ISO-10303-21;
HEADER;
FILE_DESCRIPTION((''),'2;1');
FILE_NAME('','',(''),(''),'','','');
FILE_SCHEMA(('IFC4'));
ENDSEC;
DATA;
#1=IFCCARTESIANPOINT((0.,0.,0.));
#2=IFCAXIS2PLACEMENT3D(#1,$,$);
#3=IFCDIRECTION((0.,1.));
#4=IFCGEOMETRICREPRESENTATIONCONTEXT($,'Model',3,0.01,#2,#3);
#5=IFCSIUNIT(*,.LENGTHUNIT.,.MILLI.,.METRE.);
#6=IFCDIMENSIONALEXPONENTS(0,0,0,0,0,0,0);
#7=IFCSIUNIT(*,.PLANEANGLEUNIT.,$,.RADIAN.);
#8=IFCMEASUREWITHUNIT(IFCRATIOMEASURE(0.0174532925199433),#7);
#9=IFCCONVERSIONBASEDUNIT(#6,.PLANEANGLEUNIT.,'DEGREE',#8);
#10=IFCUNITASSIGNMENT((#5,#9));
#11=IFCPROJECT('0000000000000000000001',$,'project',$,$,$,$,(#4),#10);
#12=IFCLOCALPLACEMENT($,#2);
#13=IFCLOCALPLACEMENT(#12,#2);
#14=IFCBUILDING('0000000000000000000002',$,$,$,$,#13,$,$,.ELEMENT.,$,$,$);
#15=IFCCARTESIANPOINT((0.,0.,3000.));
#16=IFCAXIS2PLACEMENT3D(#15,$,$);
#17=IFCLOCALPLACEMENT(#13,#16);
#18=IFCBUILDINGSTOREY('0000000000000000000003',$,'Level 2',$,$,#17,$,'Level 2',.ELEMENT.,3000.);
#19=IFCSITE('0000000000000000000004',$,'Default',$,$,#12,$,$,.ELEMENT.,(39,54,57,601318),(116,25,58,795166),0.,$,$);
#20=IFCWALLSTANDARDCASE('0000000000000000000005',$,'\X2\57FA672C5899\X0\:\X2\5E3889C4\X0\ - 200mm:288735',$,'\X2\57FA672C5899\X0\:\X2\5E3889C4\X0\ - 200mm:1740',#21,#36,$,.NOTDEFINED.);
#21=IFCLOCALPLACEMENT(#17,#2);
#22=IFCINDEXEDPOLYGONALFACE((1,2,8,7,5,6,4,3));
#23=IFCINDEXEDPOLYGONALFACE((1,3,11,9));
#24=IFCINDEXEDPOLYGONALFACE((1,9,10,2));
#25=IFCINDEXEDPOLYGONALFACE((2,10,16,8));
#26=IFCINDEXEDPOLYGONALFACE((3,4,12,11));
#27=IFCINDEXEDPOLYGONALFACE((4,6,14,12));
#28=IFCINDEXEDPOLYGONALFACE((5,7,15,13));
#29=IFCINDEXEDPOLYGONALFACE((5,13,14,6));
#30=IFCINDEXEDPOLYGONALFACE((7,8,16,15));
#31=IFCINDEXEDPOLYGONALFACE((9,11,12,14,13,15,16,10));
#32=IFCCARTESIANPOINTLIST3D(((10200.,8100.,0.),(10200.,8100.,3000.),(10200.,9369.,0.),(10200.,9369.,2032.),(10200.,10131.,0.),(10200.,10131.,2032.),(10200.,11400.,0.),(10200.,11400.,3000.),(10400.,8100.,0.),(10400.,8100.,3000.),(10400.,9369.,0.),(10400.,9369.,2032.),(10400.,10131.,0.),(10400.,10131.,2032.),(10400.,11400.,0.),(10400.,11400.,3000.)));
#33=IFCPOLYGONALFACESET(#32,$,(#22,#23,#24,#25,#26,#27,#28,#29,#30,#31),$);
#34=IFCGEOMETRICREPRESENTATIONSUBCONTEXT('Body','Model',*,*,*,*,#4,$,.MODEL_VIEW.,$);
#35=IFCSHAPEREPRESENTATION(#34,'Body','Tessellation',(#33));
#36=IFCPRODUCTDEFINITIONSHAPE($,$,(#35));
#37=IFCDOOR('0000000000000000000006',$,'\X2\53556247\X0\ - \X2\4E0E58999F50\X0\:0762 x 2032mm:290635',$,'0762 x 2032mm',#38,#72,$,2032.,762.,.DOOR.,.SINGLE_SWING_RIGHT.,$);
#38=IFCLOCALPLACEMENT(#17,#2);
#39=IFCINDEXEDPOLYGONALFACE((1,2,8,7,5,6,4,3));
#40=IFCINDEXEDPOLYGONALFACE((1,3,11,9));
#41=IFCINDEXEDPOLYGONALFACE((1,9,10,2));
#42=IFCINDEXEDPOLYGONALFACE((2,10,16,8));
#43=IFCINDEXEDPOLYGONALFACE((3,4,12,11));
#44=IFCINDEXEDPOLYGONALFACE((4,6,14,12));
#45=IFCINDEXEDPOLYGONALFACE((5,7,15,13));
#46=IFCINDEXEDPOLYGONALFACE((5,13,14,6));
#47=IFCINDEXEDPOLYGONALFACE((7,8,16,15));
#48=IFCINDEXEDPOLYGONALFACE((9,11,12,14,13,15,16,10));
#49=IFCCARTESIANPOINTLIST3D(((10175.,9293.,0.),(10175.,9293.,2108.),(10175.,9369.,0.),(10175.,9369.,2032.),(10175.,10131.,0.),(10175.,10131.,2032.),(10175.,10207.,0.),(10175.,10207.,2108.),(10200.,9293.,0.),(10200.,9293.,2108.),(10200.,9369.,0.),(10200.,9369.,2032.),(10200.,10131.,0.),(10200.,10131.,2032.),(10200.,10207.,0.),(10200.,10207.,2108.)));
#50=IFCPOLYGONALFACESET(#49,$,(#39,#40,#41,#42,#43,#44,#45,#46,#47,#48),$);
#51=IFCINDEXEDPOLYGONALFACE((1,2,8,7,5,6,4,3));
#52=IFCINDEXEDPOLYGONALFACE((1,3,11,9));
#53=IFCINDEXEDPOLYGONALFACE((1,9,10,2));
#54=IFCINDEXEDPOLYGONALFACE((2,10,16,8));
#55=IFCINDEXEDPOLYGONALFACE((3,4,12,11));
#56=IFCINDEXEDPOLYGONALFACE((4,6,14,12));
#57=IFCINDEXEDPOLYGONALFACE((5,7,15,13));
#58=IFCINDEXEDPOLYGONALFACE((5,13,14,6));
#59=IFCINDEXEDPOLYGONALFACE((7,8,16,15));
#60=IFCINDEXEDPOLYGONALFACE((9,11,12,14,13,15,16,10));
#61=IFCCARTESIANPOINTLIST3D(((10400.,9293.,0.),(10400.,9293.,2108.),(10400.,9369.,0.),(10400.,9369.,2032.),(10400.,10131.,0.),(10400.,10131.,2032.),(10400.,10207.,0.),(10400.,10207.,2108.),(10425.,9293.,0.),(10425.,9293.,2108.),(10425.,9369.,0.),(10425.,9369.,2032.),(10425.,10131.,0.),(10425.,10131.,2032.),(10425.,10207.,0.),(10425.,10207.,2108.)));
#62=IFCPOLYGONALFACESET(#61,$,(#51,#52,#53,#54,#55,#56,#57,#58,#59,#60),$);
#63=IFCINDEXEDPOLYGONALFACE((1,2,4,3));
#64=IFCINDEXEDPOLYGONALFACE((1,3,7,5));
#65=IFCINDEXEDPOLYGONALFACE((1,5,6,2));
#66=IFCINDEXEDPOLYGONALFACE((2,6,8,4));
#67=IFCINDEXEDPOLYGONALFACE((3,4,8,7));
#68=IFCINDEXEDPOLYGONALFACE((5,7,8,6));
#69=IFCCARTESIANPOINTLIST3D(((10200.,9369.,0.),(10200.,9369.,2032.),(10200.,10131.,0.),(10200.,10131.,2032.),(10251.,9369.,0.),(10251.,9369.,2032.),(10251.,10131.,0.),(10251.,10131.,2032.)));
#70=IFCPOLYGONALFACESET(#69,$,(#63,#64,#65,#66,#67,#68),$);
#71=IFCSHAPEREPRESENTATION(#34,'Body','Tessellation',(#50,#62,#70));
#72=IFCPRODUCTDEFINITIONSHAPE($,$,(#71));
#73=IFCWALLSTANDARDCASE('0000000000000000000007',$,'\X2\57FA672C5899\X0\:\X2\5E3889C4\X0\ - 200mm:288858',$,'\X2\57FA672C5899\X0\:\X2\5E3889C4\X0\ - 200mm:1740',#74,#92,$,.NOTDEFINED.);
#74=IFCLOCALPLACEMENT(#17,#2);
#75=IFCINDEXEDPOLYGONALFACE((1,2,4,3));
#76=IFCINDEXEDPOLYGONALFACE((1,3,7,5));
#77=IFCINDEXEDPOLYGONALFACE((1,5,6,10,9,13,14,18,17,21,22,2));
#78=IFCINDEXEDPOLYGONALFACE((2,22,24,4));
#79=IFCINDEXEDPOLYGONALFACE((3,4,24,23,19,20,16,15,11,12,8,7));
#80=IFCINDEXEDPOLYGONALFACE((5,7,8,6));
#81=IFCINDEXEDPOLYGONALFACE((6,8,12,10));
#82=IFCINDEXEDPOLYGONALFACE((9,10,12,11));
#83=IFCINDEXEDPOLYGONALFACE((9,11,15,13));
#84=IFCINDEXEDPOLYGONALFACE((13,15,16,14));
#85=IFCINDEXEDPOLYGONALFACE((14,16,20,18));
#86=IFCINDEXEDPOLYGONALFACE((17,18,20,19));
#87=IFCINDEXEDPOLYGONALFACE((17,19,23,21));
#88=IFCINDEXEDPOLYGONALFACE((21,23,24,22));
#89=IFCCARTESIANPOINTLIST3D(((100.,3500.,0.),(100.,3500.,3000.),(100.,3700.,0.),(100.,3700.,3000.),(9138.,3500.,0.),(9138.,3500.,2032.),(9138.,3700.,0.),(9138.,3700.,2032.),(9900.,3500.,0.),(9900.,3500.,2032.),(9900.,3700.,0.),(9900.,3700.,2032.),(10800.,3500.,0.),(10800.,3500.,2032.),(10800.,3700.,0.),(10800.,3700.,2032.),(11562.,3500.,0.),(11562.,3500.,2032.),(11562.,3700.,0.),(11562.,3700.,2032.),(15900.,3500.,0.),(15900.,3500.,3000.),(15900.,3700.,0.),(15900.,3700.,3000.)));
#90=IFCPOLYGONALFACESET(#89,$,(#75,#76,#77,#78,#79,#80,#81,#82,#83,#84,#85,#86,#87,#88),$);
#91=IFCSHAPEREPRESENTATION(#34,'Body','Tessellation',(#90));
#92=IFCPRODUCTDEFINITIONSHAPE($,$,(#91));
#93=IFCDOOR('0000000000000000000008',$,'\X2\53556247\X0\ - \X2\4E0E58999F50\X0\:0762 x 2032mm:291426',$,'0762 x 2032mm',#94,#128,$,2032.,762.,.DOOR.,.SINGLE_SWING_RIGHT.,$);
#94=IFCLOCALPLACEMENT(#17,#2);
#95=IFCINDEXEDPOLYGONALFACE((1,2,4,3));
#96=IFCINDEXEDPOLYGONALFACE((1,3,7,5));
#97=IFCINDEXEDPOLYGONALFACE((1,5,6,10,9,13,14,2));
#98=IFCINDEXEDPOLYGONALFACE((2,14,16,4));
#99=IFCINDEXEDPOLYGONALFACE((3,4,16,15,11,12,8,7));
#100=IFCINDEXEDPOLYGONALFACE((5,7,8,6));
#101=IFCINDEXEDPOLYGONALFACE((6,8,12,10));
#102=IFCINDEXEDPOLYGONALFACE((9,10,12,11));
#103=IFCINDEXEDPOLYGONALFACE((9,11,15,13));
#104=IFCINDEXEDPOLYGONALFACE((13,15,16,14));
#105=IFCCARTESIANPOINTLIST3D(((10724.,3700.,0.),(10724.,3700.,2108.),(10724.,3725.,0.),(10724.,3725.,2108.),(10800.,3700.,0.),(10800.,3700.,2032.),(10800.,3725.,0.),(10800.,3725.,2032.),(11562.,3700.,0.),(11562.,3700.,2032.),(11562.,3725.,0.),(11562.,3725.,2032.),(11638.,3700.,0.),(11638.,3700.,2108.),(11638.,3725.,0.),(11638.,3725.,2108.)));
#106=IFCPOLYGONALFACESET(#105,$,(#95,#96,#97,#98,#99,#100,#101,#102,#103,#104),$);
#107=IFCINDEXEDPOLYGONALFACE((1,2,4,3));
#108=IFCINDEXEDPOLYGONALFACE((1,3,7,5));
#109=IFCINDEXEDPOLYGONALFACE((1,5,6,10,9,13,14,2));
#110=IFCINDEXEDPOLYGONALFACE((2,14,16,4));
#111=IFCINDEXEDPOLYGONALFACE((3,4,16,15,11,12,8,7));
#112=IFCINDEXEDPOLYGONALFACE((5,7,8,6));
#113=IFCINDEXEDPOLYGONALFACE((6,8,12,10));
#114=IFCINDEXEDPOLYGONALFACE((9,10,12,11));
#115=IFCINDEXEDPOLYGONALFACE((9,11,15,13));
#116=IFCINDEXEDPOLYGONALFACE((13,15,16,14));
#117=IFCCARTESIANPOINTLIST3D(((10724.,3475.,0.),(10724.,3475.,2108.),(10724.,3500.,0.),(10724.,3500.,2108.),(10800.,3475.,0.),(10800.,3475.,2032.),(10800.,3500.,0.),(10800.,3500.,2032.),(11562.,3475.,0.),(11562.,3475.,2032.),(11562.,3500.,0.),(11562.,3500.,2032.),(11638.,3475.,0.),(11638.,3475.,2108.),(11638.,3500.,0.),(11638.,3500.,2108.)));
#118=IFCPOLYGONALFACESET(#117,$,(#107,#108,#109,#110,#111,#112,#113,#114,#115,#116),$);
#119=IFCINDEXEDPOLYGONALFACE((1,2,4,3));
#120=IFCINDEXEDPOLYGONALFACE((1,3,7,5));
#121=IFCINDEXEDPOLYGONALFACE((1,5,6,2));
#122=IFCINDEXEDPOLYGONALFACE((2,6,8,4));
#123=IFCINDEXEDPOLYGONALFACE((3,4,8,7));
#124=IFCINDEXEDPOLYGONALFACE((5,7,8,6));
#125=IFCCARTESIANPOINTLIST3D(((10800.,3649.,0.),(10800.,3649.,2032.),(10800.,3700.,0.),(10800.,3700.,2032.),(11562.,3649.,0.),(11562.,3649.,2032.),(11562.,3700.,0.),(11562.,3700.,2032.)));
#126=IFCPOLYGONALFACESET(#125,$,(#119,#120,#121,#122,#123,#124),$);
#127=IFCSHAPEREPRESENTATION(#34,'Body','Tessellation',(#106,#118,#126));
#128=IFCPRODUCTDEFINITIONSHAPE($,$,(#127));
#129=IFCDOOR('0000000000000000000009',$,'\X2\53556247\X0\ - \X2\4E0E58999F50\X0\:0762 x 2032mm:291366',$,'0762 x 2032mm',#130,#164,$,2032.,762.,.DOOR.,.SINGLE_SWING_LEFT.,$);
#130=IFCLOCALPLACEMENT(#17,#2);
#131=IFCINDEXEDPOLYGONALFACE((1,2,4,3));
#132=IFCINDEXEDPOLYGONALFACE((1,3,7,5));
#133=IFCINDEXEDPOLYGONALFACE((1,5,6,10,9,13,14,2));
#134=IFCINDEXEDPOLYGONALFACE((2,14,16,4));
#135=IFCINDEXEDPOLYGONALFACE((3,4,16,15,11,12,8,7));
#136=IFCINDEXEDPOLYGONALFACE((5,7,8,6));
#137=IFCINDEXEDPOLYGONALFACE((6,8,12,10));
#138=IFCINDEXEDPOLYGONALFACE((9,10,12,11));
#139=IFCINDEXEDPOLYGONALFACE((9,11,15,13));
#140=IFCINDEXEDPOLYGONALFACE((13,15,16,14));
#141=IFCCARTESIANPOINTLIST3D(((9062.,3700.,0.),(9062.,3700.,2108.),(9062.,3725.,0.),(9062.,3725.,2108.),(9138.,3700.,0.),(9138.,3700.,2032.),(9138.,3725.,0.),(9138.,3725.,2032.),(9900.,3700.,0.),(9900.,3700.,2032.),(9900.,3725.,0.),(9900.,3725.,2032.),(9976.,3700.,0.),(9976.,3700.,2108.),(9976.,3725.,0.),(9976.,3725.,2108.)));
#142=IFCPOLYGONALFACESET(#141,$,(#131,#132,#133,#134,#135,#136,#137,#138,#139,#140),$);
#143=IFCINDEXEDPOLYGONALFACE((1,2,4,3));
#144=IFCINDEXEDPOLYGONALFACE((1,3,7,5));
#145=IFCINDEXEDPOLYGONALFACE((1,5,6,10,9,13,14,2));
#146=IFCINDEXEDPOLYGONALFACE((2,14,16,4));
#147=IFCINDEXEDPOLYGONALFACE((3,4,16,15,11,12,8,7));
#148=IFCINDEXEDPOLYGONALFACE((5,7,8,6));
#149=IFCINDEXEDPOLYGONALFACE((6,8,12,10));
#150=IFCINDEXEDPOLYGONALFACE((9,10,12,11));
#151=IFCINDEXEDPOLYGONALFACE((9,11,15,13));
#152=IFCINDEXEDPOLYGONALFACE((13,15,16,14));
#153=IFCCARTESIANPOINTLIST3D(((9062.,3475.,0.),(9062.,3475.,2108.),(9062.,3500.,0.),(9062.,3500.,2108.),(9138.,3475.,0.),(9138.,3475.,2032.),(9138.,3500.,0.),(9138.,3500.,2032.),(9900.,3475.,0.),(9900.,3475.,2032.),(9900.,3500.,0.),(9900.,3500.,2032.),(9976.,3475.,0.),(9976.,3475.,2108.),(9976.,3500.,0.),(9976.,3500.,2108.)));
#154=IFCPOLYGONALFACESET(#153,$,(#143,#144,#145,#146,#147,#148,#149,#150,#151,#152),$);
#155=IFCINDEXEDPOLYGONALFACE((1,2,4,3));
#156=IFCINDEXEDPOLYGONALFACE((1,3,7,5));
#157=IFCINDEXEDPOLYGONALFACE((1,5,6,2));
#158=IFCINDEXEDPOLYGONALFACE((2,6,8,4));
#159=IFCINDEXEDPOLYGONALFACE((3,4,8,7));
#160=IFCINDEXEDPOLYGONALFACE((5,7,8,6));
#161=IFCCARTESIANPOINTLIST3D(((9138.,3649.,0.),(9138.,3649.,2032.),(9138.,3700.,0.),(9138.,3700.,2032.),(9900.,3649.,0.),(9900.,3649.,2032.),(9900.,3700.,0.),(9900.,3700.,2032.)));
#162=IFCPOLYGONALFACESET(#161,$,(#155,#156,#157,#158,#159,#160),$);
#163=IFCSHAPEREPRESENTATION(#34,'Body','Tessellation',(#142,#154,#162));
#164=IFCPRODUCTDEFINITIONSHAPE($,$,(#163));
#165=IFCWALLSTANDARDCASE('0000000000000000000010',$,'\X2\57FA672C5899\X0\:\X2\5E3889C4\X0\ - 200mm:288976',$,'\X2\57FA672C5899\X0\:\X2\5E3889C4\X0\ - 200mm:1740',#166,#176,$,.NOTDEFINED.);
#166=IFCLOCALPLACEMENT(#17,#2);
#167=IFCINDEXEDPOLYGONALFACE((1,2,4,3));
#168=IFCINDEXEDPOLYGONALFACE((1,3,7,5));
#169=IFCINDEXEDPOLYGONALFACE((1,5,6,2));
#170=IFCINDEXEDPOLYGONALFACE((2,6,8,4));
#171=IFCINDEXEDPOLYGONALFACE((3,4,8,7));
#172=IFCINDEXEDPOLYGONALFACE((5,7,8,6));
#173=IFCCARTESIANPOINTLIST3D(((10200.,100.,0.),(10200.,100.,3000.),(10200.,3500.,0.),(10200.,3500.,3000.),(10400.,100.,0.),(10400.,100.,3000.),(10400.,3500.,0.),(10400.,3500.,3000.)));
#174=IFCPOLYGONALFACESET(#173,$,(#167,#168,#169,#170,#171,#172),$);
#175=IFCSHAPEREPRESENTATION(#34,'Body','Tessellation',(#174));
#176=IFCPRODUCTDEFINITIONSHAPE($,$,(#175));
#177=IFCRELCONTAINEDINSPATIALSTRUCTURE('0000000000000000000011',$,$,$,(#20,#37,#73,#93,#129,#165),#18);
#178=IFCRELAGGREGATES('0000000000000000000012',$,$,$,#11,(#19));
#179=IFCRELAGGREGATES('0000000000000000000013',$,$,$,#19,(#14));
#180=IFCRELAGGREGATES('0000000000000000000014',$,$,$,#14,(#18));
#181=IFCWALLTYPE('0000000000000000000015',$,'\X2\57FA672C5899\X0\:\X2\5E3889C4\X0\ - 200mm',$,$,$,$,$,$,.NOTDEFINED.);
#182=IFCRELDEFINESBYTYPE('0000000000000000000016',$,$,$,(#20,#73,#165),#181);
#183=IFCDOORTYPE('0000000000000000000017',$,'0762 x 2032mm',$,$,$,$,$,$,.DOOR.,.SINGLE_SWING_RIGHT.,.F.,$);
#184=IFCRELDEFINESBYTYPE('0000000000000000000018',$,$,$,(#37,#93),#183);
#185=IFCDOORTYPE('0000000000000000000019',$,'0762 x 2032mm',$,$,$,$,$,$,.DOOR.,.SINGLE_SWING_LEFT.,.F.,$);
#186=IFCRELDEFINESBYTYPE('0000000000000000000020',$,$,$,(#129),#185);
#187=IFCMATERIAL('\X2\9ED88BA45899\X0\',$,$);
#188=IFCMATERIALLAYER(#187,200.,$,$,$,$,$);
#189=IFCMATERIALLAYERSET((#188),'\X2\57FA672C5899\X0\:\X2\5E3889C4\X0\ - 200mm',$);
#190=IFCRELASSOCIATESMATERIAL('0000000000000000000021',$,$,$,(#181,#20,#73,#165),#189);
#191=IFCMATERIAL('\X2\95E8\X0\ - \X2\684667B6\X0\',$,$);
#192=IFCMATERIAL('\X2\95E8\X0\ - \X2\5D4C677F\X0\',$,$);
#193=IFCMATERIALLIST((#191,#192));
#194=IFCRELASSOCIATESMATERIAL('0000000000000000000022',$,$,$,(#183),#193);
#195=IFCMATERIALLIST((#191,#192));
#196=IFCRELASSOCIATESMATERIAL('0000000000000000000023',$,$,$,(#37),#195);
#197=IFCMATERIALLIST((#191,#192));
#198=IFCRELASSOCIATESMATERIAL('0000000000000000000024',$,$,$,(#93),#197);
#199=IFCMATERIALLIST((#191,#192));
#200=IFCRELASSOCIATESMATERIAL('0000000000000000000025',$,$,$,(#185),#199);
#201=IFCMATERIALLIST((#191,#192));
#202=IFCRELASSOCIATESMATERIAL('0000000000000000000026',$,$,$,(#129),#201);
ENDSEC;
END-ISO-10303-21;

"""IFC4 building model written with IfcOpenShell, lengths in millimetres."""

from ifc_helpers import new_model, entity, si_unit, converted_unit, direction, frame, frame_2d, origin, place, context, subcontext, project, spatial, polyline, rectangle, outline, extrude, source, transform, mapped, material, material_list, layer, layer_set, layer_usage, type_object, type_shapes, element, fill, save


model = new_model("IFC4")

# Units and contexts
model_context = context("Model", 3, precision=0.01, world=origin(), true_north=direction((0.0, 1.0)))
body_context = subcontext(model_context, "Body", "Model", "MODEL_VIEW")
ifc_project = project(units=[si_unit("LENGTHUNIT", "METRE", prefix="MILLI"), converted_unit("PLANEANGLEUNIT", "DEGREE", entity("IfcRatioMeasure", 0.0174532925199433), si_unit("PLANEANGLEUNIT", "RADIAN"), dimensions=[0, 0, 0, 0, 0, 0, 0])], contexts=[model_context])

# Site, building, storey
site_placement = place(None, origin())
site = spatial("IfcSite", under=ifc_project, at=site_placement, Name="Default", CompositionType="ELEMENT", RefLatitude=(39, 54, 57, 601318), RefLongitude=(116, 25, 58, 795166), RefElevation=0.0)
building_placement = place(site_placement, origin())
building = spatial("IfcBuilding", under=site, at=building_placement, CompositionType="ELEMENT")
storey_placement = place(building_placement, frame((0.0, 0.0, 3000.0)))
storey = spatial("IfcBuildingStorey", under=building, at=storey_placement, Name="Level 2", LongName="Level 2", CompositionType="ELEMENT", Elevation=3000.0)

# Shared definitions
ifc_material_1 = material(Name="默认墙")
ifc_layer = layer(ifc_material_1, 200.0)
ifc_layer_set = layer_set([ifc_layer], Name="基本墙:常规 - 200mm")
wall_type = type_object("IfcWallType", Name="基本墙:常规 - 200mm", PredefinedType="NOTDEFINED", material=ifc_layer_set)

# Wall, opening, door
ifc_layer_usage_1 = layer_usage(ifc_layer_set, "AXIS2", "NEGATIVE", 100.0)
wall_1_placement = place(storey_placement, frame((10300.0, 11400.0, 0.0), z_axis=(0.0, 0.0, 1.0), x_axis=(0.0, -1.0, 0.0)))
wall_1 = element("IfcWallStandardCase", 1, at=wall_1_placement, inside=storey, type_object=wall_type, material=ifc_layer_usage_1, Name="基本墙:常规 - 200mm:288735", ObjectType="基本墙:常规 - 200mm:1740", PredefinedType="NOTDEFINED", context=body_context, shape_type="SweptSolid", body=[
    extrude(rectangle(XDim=3300.0, YDim=200.0, at=frame_2d((1650.0, 0.0), x_axis=(-1.0, 0.0))), origin(), (0.0, 0.0, 1.0), 3000.0),
])
opening_1_placement = place(wall_1_placement, frame((2031.0, 100.0, 0.0)))
opening_1 = element("IfcOpeningElement", 2, at=opening_1_placement, cuts=wall_1, ObjectType="Opening", PredefinedType="OPENING", context=body_context, shape_type="SweptSolid", body=[
    extrude(rectangle(XDim=762.0, YDim=2032.0, at=frame_2d((1016.0, 381.0), x_axis=(0.0, 1.0))), frame((0.0, 0.0, 0.0), z_axis=(0.0, -1.0, 0.0), x_axis=(0.0, 0.0, 1.0)), (0.0, 0.0, 1.0), 200.0),
])
ifc_material_2 = material(Name="门 - 框架")
ifc_material_3 = material(Name="门 - 嵌板")
ifc_material_list_1 = material_list([ifc_material_2, ifc_material_3])
ifc_material_list_2 = material_list([ifc_material_2, ifc_material_3])
door_type_1 = type_object("IfcDoorType", Name="0762 x 2032mm", OperationType="SINGLE_SWING_RIGHT", ParameterTakesPrecedence=False, PredefinedType="DOOR", material=ifc_material_list_2)
shared_shape_1 = source(origin(), body_context, "Body", "SweptSolid", [
    extrude(outline(polyline([(-457.0, -1073.0), (457.0, -1073.0), (457.0, 1035.0), (381.0, 1035.0), (381.0, -997.0), (-381.0, -997.0), (-381.0, 1035.0), (-457.0, 1035.0), (-457.0, -1073.0)])), frame((381.0, 200.0, 1035.0), z_axis=(0.0, 1.0, 0.0), x_axis=(1.0, 0.0, 0.0)), (0.0, 0.0, 1.0), 25.0),
    extrude(outline(polyline([(-1073.0, -457.0), (1035.0, -457.0), (1035.0, -381.0), (-997.0, -381.0), (-997.0, 381.0), (1035.0, 381.0), (1035.0, 457.0), (-1073.0, 457.0), (-1073.0, -457.0)])), frame((381.0, -25.0, 1035.0), z_axis=(0.0, 1.0, 0.0), x_axis=(0.0, 0.0, -1.0)), (0.0, 0.0, 1.0), 25.0),
    extrude(rectangle(XDim=51.0, YDim=762.0, at=frame_2d((0.0, 0.0), x_axis=(1.0, 0.0))), frame((381.0, 174.5, 0.0), z_axis=(0.0, 0.0, 1.0), x_axis=(0.0, 1.0, 0.0)), (0.0, 0.0, 1.0), 2032.0),
])
type_shapes(door_type_1, [shared_shape_1])
door_1_placement = place(opening_1_placement, frame((0.0, 0.0, 0.0), z_axis=(0.0, 0.0, 1.0), x_axis=(-1.0, 0.0, 0.0)))
door_1 = element("IfcDoor", 3, at=door_1_placement, inside=storey, type_object=door_type_1, material=ifc_material_list_1, Name="单扇 - 与墙齐:0762 x 2032mm:290635", ObjectType="0762 x 2032mm", OperationType="SINGLE_SWING_RIGHT", OverallHeight=2032.0, OverallWidth=762.0, PredefinedType="DOOR", context=body_context, shape_type="MappedRepresentation", body=[
    mapped(shared_shape_1, transform((0.0, 0.0, 0.0), scale=1.0)),
])
fill(opening_1, door_1)

# Wall, openings, doors
ifc_layer_usage_2 = layer_usage(ifc_layer_set, "AXIS2", "NEGATIVE", 100.0)
wall_2_placement = place(storey_placement, frame((15900.0, 3600.0, 0.0), z_axis=(0.0, 0.0, 1.0), x_axis=(-1.0, 0.0, 0.0)))
wall_2 = element("IfcWallStandardCase", 4, at=wall_2_placement, inside=storey, type_object=wall_type, material=ifc_layer_usage_2, Name="基本墙:常规 - 200mm:288858", ObjectType="基本墙:常规 - 200mm:1740", PredefinedType="NOTDEFINED", context=body_context, shape_type="SweptSolid", body=[
    extrude(rectangle(XDim=15800.0, YDim=200.0, at=frame_2d((7900.0, 0.0), x_axis=(-1.0, 0.0))), origin(), (0.0, 0.0, 1.0), 3000.0),
])
opening_2_placement = place(wall_2_placement, frame((6762.0, 100.0, 0.0)))
opening_2 = element("IfcOpeningElement", 5, at=opening_2_placement, cuts=wall_2, ObjectType="Opening", PredefinedType="OPENING", context=body_context, shape_type="SweptSolid", body=[
    extrude(rectangle(XDim=762.0, YDim=2032.0, at=frame_2d((1016.0, 381.0), x_axis=(0.0, -1.0))), frame((0.0, 0.0, 0.0), z_axis=(0.0, -1.0, 0.0), x_axis=(0.0, 0.0, 1.0)), (0.0, 0.0, 1.0), 200.0),
])
opening_3_placement = place(wall_2_placement, frame((5100.0, 100.0, 0.0)))
opening_3 = element("IfcOpeningElement", 6, at=opening_3_placement, cuts=wall_2, ObjectType="Opening", PredefinedType="OPENING", context=body_context, shape_type="SweptSolid", body=[
    extrude(rectangle(XDim=762.0, YDim=2032.0, at=frame_2d((1016.0, 381.0), x_axis=(0.0, 1.0))), frame((0.0, 0.0, 0.0), z_axis=(0.0, -1.0, 0.0), x_axis=(0.0, 0.0, 1.0)), (0.0, 0.0, 1.0), 200.0),
])
ifc_material_list_3 = material_list([ifc_material_2, ifc_material_3])
door_2_placement = place(opening_3_placement, frame((0.0, 0.0, 0.0), z_axis=(0.0, 0.0, 1.0), x_axis=(-1.0, 0.0, 0.0)))
door_2 = element("IfcDoor", 7, at=door_2_placement, inside=storey, type_object=door_type_1, material=ifc_material_list_3, Name="单扇 - 与墙齐:0762 x 2032mm:291426", ObjectType="0762 x 2032mm", OperationType="SINGLE_SWING_RIGHT", OverallHeight=2032.0, OverallWidth=762.0, PredefinedType="DOOR", context=body_context, shape_type="MappedRepresentation", body=[
    mapped(shared_shape_1, transform((0.0, 0.0, 0.0), scale=1.0)),
])
fill(opening_3, door_2)
ifc_material_list_4 = material_list([ifc_material_2, ifc_material_3])
ifc_material_list_5 = material_list([ifc_material_2, ifc_material_3])
door_type_2 = type_object("IfcDoorType", Name="0762 x 2032mm", OperationType="SINGLE_SWING_LEFT", ParameterTakesPrecedence=False, PredefinedType="DOOR", material=ifc_material_list_5)
shared_shape_2 = source(origin(), body_context, "Body", "SweptSolid", [
    extrude(outline(polyline([(-457.0, -1073.0), (457.0, -1073.0), (457.0, 1035.0), (381.0, 1035.0), (381.0, -997.0), (-381.0, -997.0), (-381.0, 1035.0), (-457.0, 1035.0), (-457.0, -1073.0)])), frame((381.0, 225.0, 1035.0), z_axis=(0.0, -1.0, 0.0), x_axis=(-1.0, 0.0, 0.0)), (0.0, 0.0, 1.0), 25.0),
    extrude(outline(polyline([(-1073.0, -457.0), (1035.0, -457.0), (1035.0, -381.0), (-997.0, -381.0), (-997.0, 381.0), (1035.0, 381.0), (1035.0, 457.0), (-1073.0, 457.0), (-1073.0, -457.0)])), frame((381.0, 0.0, 1035.0), z_axis=(0.0, -1.0, 0.0), x_axis=(0.0, 0.0, -1.0)), (0.0, 0.0, 1.0), 25.0),
    extrude(rectangle(XDim=762.0, YDim=51.0, at=frame_2d((0.0, 0.0), x_axis=(1.0, 0.0))), frame((381.0, 174.5, 0.0)), (0.0, 0.0, 1.0), 2032.0),
])
type_shapes(door_type_2, [shared_shape_2])
door_3_placement = place(opening_2_placement, frame((0.0, 0.0, 0.0), z_axis=(0.0, 0.0, 1.0), x_axis=(-1.0, 0.0, 0.0)))
door_3 = element("IfcDoor", 8, at=door_3_placement, inside=storey, type_object=door_type_2, material=ifc_material_list_4, Name="单扇 - 与墙齐:0762 x 2032mm:291366", ObjectType="0762 x 2032mm", OperationType="SINGLE_SWING_LEFT", OverallHeight=2032.0, OverallWidth=762.0, PredefinedType="DOOR", context=body_context, shape_type="MappedRepresentation", body=[
    mapped(shared_shape_2, transform((0.0, 0.0, 0.0), scale=1.0)),
])
fill(opening_2, door_3)

# Wall
ifc_layer_usage_3 = layer_usage(ifc_layer_set, "AXIS2", "NEGATIVE", 100.0)
wall_3_placement = place(storey_placement, frame((10300.0, 3500.0, 0.0), z_axis=(0.0, 0.0, 1.0), x_axis=(0.0, -1.0, 0.0)))
element("IfcWallStandardCase", 9, at=wall_3_placement, inside=storey, type_object=wall_type, material=ifc_layer_usage_3, Name="基本墙:常规 - 200mm:288976", ObjectType="基本墙:常规 - 200mm:1740", PredefinedType="NOTDEFINED", context=body_context, shape_type="SweptSolid", body=[
    extrude(rectangle(XDim=3400.0, YDim=200.0, at=frame_2d((1700.0, 0.0), x_axis=(-1.0, 0.0))), origin(), (0.0, 0.0, 1.0), 3000.0),
])

save(model, "model.ifc")
